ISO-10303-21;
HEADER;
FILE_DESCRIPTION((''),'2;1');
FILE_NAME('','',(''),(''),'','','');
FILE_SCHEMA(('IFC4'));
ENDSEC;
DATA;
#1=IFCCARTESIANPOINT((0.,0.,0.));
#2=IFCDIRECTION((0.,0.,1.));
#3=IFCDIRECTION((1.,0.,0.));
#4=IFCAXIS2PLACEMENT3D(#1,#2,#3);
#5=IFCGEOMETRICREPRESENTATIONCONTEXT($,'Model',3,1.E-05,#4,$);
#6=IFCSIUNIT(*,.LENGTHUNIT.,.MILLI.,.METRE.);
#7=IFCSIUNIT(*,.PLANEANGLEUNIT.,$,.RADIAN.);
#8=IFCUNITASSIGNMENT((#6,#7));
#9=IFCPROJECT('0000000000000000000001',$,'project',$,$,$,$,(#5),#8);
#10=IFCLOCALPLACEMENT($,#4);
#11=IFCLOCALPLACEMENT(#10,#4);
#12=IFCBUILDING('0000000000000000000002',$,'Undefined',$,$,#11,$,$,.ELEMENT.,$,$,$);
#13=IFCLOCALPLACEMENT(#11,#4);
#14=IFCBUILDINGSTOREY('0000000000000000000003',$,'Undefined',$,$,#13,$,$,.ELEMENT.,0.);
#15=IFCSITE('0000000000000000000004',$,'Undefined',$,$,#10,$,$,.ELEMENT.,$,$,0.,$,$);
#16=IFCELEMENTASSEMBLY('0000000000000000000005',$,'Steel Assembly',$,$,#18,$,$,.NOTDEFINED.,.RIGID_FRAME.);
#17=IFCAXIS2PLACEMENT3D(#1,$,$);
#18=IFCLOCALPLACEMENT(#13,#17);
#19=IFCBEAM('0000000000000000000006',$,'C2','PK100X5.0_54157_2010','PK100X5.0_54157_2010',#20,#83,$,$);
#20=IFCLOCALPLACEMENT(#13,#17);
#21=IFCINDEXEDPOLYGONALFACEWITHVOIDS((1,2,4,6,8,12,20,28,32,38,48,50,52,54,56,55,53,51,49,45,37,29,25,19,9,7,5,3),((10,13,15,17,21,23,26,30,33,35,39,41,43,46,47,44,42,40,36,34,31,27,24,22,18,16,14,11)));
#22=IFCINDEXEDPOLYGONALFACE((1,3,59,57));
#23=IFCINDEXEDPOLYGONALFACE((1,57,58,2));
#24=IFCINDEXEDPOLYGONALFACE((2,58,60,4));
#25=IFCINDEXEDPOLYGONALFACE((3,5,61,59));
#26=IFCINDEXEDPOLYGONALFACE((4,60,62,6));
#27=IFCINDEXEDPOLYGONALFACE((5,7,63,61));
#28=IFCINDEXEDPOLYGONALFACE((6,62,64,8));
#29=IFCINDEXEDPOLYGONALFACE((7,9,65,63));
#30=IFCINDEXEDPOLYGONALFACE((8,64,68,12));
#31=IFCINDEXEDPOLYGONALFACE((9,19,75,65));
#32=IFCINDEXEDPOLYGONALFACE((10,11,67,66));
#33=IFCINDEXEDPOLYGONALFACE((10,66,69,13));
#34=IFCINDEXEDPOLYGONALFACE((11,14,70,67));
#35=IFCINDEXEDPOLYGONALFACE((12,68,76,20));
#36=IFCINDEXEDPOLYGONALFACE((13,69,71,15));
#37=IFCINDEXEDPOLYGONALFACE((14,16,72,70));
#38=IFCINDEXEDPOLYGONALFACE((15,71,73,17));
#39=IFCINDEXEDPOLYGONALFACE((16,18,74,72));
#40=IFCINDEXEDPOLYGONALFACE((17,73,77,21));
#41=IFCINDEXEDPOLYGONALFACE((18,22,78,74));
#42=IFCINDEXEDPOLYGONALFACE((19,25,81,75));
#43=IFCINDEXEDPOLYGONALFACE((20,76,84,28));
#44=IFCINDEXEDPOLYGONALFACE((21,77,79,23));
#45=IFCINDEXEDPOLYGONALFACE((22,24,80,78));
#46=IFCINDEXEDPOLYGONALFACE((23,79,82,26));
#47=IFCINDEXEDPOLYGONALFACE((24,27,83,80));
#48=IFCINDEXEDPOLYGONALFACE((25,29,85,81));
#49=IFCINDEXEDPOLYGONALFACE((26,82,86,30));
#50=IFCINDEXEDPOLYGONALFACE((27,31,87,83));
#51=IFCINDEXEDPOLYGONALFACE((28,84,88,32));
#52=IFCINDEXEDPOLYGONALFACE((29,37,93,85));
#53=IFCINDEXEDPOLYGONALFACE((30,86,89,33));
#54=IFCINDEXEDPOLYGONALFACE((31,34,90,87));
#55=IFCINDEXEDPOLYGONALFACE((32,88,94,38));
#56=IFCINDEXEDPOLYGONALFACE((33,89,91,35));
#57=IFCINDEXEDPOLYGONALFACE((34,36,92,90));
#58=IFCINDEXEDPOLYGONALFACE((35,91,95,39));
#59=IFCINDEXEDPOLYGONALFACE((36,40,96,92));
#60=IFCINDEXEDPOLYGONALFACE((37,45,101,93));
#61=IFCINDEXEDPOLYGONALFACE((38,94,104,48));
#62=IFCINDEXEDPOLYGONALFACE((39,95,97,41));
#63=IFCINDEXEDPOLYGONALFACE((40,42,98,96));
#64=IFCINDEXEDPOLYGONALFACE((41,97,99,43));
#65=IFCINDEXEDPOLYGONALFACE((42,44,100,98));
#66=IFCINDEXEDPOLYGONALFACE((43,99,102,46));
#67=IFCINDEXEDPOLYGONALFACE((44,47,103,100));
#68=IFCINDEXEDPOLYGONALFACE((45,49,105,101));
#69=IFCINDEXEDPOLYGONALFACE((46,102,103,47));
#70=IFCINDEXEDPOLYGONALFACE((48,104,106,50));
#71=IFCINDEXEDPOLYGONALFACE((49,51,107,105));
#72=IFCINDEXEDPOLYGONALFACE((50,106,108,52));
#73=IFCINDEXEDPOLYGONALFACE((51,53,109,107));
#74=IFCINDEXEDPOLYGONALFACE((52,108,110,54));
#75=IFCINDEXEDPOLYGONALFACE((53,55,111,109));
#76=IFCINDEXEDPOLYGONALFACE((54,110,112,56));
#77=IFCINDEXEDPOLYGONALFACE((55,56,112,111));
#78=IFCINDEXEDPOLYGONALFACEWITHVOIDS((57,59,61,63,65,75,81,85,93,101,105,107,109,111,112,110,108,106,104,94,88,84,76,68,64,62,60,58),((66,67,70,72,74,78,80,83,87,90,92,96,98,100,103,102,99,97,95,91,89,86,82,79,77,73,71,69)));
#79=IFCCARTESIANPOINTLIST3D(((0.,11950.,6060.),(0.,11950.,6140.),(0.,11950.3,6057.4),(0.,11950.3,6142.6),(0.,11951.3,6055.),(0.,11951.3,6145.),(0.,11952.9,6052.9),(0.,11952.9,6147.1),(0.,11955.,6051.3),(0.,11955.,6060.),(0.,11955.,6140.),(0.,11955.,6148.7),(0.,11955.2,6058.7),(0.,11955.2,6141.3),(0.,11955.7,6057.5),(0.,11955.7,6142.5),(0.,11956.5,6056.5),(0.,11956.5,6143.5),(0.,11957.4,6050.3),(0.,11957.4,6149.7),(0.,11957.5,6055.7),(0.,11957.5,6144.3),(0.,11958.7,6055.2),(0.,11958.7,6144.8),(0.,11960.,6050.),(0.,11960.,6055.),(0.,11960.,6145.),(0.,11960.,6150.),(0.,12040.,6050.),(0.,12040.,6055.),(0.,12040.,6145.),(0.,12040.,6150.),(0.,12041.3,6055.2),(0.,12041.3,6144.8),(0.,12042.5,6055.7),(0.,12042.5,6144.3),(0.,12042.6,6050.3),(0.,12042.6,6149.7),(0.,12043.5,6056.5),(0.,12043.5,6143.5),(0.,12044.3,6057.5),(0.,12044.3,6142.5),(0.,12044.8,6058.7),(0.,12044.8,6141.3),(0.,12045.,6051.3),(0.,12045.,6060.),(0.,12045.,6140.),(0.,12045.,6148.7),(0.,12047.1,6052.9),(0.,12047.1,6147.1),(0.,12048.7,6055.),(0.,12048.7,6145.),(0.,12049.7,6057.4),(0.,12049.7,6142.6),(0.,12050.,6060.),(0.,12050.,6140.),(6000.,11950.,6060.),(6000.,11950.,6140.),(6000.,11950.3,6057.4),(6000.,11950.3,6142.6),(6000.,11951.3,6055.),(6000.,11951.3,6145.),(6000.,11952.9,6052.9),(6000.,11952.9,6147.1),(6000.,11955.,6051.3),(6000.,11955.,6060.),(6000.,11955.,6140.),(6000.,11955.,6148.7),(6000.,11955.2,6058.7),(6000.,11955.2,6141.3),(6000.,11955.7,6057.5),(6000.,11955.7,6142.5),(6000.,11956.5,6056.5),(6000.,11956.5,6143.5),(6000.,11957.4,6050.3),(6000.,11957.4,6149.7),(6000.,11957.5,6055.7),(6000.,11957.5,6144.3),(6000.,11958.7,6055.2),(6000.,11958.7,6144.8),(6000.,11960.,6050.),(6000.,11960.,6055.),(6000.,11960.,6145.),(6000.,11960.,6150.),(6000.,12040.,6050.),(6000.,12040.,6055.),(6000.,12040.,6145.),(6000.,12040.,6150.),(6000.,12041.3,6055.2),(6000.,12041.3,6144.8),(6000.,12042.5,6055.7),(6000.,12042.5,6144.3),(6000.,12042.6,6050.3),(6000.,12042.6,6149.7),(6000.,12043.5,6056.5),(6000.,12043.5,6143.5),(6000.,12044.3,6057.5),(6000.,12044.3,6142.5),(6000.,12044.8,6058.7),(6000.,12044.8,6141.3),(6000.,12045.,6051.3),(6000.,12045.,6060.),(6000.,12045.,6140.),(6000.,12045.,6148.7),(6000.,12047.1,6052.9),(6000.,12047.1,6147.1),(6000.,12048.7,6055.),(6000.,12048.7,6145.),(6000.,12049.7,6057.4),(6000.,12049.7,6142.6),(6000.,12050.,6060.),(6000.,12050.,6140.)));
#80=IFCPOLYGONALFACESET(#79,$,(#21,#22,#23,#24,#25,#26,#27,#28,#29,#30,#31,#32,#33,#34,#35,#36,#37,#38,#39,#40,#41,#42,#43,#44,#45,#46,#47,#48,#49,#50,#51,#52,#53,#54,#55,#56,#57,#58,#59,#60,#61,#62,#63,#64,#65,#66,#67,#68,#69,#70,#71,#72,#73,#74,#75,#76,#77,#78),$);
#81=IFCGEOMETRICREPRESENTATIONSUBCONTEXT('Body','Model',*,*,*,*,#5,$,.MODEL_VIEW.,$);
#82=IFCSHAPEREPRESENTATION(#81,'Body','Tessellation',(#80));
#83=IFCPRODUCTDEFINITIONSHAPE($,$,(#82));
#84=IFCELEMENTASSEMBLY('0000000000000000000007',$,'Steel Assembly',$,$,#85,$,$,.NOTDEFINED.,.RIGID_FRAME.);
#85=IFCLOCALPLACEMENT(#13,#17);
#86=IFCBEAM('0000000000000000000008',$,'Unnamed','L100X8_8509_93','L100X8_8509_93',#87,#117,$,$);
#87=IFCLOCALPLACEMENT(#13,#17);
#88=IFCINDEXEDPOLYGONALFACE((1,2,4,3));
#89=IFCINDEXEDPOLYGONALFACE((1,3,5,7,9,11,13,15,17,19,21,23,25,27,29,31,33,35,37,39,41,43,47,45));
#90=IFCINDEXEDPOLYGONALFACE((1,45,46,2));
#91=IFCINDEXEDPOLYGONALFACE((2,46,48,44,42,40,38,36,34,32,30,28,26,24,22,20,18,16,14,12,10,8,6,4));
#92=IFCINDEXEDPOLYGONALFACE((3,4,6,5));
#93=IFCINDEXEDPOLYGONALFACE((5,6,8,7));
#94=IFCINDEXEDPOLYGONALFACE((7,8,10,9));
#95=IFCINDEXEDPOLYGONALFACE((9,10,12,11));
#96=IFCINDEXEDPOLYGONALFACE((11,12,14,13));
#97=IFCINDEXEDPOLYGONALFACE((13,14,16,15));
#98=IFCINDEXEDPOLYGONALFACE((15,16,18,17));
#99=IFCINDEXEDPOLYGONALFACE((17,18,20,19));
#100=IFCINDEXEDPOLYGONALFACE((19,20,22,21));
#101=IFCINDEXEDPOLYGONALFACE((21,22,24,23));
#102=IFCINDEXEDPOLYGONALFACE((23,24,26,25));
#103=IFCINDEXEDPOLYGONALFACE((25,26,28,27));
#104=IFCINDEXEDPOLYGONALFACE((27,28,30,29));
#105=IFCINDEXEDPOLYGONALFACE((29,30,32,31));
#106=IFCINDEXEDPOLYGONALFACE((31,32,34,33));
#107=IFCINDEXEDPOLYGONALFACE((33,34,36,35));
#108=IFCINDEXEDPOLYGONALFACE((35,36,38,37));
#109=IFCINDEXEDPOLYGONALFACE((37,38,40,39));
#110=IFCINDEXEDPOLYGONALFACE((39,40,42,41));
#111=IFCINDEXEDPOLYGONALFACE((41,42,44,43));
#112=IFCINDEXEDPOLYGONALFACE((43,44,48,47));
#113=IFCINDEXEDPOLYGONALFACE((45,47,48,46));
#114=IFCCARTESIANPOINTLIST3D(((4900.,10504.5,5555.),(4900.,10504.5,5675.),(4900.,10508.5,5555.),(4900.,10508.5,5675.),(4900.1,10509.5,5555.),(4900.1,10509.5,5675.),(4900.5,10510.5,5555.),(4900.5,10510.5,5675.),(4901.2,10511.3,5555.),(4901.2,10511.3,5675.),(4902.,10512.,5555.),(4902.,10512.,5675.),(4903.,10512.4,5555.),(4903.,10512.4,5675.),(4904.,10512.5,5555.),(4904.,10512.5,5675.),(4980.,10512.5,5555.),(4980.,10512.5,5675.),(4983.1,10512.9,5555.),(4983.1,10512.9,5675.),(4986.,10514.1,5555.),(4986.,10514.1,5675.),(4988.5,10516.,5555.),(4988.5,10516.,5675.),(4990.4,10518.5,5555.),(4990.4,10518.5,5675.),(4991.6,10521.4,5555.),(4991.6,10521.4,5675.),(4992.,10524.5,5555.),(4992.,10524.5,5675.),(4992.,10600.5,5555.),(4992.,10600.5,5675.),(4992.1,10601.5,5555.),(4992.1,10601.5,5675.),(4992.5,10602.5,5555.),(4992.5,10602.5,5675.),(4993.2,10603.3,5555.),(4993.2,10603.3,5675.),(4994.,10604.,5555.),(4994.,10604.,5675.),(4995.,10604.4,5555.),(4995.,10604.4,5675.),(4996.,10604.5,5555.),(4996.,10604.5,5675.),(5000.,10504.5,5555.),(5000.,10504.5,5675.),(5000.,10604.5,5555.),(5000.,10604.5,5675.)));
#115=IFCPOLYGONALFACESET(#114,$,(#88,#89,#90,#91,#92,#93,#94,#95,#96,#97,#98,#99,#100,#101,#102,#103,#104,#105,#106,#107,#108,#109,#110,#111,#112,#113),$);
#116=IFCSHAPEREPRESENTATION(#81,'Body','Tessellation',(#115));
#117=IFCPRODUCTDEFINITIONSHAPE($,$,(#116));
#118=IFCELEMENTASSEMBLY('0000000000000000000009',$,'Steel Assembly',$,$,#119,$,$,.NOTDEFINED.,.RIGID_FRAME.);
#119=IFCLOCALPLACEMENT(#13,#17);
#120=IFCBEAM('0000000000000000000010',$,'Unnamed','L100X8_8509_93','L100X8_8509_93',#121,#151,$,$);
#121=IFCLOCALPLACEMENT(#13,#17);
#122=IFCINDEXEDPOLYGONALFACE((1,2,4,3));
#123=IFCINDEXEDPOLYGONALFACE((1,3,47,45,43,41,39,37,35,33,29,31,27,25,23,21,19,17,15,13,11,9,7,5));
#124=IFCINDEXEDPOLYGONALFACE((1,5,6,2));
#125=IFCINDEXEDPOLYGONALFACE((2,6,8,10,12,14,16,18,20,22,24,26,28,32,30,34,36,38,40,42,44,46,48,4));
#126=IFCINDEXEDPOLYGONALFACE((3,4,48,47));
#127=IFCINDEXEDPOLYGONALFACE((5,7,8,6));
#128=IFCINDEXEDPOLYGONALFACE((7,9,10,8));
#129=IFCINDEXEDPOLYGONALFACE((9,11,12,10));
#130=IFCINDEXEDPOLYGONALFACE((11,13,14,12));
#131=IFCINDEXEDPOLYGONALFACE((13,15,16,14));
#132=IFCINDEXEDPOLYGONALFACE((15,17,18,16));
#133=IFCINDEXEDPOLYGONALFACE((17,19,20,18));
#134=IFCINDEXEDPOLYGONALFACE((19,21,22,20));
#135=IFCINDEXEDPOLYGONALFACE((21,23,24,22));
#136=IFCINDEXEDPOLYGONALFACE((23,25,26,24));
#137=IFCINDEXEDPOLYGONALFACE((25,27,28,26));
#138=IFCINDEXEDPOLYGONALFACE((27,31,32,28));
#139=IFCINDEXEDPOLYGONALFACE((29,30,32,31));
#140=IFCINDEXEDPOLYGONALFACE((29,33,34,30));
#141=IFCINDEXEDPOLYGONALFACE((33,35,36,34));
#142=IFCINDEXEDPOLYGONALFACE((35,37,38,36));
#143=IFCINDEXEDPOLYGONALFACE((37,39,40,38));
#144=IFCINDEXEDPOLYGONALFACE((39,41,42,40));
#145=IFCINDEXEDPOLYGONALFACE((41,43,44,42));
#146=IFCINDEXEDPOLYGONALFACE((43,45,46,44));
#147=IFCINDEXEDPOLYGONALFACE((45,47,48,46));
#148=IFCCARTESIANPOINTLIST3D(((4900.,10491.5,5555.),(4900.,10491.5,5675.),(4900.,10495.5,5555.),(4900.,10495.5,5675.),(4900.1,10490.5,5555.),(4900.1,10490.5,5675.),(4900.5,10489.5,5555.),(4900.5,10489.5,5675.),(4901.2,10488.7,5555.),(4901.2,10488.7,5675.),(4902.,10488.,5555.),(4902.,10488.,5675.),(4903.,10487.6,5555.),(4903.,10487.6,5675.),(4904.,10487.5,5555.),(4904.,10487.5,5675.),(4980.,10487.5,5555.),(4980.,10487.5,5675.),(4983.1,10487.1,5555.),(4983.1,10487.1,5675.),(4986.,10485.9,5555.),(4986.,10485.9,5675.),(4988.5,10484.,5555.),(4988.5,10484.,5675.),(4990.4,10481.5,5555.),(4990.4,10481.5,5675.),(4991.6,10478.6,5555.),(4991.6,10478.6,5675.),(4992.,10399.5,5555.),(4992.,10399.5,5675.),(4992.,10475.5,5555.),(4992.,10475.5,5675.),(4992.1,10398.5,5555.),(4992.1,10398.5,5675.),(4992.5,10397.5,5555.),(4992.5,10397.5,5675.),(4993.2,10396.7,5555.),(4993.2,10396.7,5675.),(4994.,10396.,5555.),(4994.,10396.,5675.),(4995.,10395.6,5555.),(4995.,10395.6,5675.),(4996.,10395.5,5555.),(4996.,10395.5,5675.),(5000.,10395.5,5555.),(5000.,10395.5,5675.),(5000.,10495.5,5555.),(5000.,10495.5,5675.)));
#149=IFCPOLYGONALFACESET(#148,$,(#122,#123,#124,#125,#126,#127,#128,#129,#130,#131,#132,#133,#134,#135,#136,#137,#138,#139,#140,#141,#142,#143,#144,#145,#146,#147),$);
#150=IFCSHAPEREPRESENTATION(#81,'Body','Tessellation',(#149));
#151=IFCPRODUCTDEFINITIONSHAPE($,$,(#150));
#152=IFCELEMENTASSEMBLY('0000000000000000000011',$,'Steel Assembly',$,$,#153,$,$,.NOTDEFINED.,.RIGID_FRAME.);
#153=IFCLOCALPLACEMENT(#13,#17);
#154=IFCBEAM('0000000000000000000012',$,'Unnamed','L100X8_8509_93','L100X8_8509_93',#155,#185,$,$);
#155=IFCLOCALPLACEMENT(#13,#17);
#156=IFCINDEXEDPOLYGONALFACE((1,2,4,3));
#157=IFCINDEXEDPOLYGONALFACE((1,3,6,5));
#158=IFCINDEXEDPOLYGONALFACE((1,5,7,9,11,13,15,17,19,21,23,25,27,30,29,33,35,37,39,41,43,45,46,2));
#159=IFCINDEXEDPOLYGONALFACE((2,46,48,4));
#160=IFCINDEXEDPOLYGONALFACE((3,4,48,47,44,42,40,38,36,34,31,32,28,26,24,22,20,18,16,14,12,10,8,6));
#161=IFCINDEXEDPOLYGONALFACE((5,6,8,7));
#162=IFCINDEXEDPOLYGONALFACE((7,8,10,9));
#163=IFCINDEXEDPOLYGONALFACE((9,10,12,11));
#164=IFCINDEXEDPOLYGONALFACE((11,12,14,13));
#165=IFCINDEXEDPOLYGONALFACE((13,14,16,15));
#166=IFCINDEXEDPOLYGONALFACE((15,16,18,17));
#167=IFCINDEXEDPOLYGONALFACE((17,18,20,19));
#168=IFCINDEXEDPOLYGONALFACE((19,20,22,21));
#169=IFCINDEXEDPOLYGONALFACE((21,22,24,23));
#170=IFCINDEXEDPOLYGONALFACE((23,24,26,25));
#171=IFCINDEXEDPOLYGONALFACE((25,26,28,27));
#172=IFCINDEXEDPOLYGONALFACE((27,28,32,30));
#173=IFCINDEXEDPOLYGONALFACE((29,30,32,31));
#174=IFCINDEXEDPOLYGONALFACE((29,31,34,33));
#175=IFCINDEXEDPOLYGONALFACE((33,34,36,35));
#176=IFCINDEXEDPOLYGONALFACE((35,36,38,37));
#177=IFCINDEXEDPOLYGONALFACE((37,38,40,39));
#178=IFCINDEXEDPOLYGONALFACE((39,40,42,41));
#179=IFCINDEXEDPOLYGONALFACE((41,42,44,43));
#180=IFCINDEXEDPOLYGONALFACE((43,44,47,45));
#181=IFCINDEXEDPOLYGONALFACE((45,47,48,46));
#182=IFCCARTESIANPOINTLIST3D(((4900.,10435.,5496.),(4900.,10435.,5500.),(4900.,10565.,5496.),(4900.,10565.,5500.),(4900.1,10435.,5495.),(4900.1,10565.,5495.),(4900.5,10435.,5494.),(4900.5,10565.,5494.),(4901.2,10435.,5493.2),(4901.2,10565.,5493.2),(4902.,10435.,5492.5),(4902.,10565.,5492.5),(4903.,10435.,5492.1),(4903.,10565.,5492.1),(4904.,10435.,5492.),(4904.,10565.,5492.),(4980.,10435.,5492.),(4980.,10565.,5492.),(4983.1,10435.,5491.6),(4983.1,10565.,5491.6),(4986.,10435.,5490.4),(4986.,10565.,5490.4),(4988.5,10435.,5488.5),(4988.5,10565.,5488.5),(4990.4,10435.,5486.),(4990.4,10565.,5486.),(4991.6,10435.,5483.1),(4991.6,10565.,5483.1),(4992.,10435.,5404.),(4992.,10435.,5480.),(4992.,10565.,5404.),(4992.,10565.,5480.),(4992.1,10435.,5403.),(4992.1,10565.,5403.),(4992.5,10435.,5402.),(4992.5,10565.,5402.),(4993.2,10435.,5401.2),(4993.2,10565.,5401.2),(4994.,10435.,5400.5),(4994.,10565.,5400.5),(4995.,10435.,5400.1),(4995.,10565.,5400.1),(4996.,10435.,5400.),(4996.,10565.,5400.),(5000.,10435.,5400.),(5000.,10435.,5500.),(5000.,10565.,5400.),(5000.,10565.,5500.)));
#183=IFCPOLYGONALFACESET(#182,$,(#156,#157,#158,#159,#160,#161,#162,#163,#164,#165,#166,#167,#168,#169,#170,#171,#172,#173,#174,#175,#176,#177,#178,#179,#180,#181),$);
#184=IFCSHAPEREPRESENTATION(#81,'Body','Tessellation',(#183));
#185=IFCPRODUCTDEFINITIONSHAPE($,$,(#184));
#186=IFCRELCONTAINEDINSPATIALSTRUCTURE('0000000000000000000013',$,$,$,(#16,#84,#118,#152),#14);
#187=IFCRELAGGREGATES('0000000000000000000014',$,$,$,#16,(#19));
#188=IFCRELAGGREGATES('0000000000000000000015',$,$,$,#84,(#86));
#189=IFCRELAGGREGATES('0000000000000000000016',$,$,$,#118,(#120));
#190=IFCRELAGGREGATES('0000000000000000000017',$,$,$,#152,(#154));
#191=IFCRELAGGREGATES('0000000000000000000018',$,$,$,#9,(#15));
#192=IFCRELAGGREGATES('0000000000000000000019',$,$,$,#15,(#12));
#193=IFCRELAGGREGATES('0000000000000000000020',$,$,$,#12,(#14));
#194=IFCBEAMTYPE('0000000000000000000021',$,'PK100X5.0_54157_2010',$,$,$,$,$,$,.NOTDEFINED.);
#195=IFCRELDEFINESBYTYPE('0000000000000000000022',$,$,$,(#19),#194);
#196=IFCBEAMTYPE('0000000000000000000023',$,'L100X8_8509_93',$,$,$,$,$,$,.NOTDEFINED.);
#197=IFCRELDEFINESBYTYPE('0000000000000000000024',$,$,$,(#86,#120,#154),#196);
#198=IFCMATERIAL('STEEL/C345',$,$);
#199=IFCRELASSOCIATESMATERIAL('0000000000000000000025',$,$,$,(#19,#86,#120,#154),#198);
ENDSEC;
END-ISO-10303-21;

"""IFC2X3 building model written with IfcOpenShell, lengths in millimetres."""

from ifc_helpers import new_model, si_unit, frame, origin_with_axes, origin_2d_with_axis, place, context, subcontext, project, spatial, hollow_rectangle, l_section, extrude, material, type_object, element, aggregate, save


model = new_model("IFC2X3")

# Units and contexts
model_context = context("Model", 3, precision=1e-05, world=origin_with_axes())
body_context = subcontext(model_context, "Body", "Model", "MODEL_VIEW")
ifc_project = project(units=[si_unit("LENGTHUNIT", "METRE", prefix="MILLI"), si_unit("PLANEANGLEUNIT", "RADIAN")], contexts=[model_context])

# Site, building, storey
site_placement = place(None, origin_with_axes())
site = spatial("IfcSite", under=ifc_project, at=site_placement, Name="Undefined", CompositionType="ELEMENT", RefElevation=0.0)
building_placement = place(site_placement, origin_with_axes())
building = spatial("IfcBuilding", under=site, at=building_placement, Name="Undefined", CompositionType="ELEMENT")
storey_placement = place(building_placement, origin_with_axes())
storey = spatial("IfcBuildingStorey", under=building, at=storey_placement, Name="Undefined", CompositionType="ELEMENT", Elevation=0.0)

# Element assemblies, beams
assembly_1_placement = place(storey_placement, origin_with_axes())
assembly_1 = element("IfcElementAssembly", 1, at=assembly_1_placement, inside=storey, Name="Steel Assembly", AssemblyPlace="NOTDEFINED", PredefinedType="RIGID_FRAME")
ifc_material_1 = material(Name="STEEL/C345")
beam_type_1 = type_object("IfcBeamType", Name="PK100X5.0_54157_2010", PredefinedType="NOTDEFINED")
beam_1_placement = place(assembly_1_placement, frame((6000.0, 12000.0, 6100.0), z_axis=(0.0, 0.0, 1.0), x_axis=(-1.0, 0.0, 0.0)))
beam_1 = element("IfcBeam", 2, at=beam_1_placement, type_object=beam_type_1, material=ifc_material_1, Name="C2", Description="PK100X5.0_54157_2010", ObjectType="PK100X5.0_54157_2010", context=body_context, shape_type="SweptSolid", body=[
    extrude(hollow_rectangle(XDim=100.0, YDim=100.0, WallThickness=5.0, InnerFilletRadius=5.0, OuterFilletRadius=10.0, at=origin_2d_with_axis()), frame((6000.0, 0.0, 0.0), z_axis=(-1.0, 0.0, 0.0), x_axis=(0.0, -1.0, 0.0)), (0.0, 0.0, 1.0), 6000.0),
])
aggregate(assembly_1, [beam_1])
assembly_2_placement = place(storey_placement, origin_with_axes())
assembly_2 = element("IfcElementAssembly", 3, at=assembly_2_placement, inside=storey, Name="Steel Assembly", AssemblyPlace="NOTDEFINED", PredefinedType="RIGID_FRAME")
beam_type_2 = type_object("IfcBeamType", Name="L100X8_8509_93", PredefinedType="NOTDEFINED")
beam_2_placement = place(assembly_2_placement, frame((4950.0, 10554.5, 5675.0), z_axis=(-1.0, 0.0, 0.0), x_axis=(0.0, 0.0, -1.0)))
beam_2 = element("IfcBeam", 4, at=beam_2_placement, type_object=beam_type_2, material=ifc_material_1, Name="Unnamed", Description="L100X8_8509_93", ObjectType="L100X8_8509_93", context=body_context, shape_type="SweptSolid", body=[
    extrude(l_section(Depth=100.0, Width=100.0, Thickness=8.0, FilletRadius=12.0, EdgeRadius=4.0, at=origin_2d_with_axis()), frame((120.0, 0.0, 0.0), z_axis=(-1.0, 0.0, 0.0), x_axis=(0.0, -1.0, 0.0)), (0.0, 0.0, 1.0), 120.0),
])
aggregate(assembly_2, [beam_2])
assembly_3_placement = place(storey_placement, origin_with_axes())
assembly_3 = element("IfcElementAssembly", 5, at=assembly_3_placement, inside=storey, Name="Steel Assembly", AssemblyPlace="NOTDEFINED", PredefinedType="RIGID_FRAME")
beam_3_placement = place(assembly_3_placement, frame((4950.0, 10445.5, 5675.0), z_axis=(0.0, -1.0, 0.0), x_axis=(0.0, 0.0, -1.0)))
beam_3 = element("IfcBeam", 6, at=beam_3_placement, type_object=beam_type_2, material=ifc_material_1, Name="Unnamed", Description="L100X8_8509_93", ObjectType="L100X8_8509_93", context=body_context, shape_type="SweptSolid", body=[
    extrude(l_section(Depth=100.0, Width=100.0, Thickness=8.0, FilletRadius=12.0, EdgeRadius=4.0, at=origin_2d_with_axis()), frame((120.0, 0.0, 0.0), z_axis=(-1.0, 0.0, 0.0), x_axis=(0.0, -1.0, 0.0)), (0.0, 0.0, 1.0), 120.0),
])
aggregate(assembly_3, [beam_3])
assembly_4_placement = place(storey_placement, origin_with_axes())
assembly_4 = element("IfcElementAssembly", 7, at=assembly_4_placement, inside=storey, Name="Steel Assembly", AssemblyPlace="NOTDEFINED", PredefinedType="RIGID_FRAME")
beam_4_placement = place(assembly_4_placement, frame((4950.0, 10565.0, 5450.0), z_axis=(-1.0, 0.0, 0.0), x_axis=(0.0, -1.0, 0.0)))
beam_4 = element("IfcBeam", 8, at=beam_4_placement, type_object=beam_type_2, material=ifc_material_1, Name="Unnamed", Description="L100X8_8509_93", ObjectType="L100X8_8509_93", context=body_context, shape_type="SweptSolid", body=[
    extrude(l_section(Depth=100.0, Width=100.0, Thickness=8.0, FilletRadius=12.0, EdgeRadius=4.0, at=origin_2d_with_axis()), frame((130.0, 0.0, 0.0), z_axis=(-1.0, 0.0, 0.0), x_axis=(0.0, -1.0, 0.0)), (0.0, 0.0, 1.0), 130.0),
])
aggregate(assembly_4, [beam_4])

save(model, "model.ifc")
